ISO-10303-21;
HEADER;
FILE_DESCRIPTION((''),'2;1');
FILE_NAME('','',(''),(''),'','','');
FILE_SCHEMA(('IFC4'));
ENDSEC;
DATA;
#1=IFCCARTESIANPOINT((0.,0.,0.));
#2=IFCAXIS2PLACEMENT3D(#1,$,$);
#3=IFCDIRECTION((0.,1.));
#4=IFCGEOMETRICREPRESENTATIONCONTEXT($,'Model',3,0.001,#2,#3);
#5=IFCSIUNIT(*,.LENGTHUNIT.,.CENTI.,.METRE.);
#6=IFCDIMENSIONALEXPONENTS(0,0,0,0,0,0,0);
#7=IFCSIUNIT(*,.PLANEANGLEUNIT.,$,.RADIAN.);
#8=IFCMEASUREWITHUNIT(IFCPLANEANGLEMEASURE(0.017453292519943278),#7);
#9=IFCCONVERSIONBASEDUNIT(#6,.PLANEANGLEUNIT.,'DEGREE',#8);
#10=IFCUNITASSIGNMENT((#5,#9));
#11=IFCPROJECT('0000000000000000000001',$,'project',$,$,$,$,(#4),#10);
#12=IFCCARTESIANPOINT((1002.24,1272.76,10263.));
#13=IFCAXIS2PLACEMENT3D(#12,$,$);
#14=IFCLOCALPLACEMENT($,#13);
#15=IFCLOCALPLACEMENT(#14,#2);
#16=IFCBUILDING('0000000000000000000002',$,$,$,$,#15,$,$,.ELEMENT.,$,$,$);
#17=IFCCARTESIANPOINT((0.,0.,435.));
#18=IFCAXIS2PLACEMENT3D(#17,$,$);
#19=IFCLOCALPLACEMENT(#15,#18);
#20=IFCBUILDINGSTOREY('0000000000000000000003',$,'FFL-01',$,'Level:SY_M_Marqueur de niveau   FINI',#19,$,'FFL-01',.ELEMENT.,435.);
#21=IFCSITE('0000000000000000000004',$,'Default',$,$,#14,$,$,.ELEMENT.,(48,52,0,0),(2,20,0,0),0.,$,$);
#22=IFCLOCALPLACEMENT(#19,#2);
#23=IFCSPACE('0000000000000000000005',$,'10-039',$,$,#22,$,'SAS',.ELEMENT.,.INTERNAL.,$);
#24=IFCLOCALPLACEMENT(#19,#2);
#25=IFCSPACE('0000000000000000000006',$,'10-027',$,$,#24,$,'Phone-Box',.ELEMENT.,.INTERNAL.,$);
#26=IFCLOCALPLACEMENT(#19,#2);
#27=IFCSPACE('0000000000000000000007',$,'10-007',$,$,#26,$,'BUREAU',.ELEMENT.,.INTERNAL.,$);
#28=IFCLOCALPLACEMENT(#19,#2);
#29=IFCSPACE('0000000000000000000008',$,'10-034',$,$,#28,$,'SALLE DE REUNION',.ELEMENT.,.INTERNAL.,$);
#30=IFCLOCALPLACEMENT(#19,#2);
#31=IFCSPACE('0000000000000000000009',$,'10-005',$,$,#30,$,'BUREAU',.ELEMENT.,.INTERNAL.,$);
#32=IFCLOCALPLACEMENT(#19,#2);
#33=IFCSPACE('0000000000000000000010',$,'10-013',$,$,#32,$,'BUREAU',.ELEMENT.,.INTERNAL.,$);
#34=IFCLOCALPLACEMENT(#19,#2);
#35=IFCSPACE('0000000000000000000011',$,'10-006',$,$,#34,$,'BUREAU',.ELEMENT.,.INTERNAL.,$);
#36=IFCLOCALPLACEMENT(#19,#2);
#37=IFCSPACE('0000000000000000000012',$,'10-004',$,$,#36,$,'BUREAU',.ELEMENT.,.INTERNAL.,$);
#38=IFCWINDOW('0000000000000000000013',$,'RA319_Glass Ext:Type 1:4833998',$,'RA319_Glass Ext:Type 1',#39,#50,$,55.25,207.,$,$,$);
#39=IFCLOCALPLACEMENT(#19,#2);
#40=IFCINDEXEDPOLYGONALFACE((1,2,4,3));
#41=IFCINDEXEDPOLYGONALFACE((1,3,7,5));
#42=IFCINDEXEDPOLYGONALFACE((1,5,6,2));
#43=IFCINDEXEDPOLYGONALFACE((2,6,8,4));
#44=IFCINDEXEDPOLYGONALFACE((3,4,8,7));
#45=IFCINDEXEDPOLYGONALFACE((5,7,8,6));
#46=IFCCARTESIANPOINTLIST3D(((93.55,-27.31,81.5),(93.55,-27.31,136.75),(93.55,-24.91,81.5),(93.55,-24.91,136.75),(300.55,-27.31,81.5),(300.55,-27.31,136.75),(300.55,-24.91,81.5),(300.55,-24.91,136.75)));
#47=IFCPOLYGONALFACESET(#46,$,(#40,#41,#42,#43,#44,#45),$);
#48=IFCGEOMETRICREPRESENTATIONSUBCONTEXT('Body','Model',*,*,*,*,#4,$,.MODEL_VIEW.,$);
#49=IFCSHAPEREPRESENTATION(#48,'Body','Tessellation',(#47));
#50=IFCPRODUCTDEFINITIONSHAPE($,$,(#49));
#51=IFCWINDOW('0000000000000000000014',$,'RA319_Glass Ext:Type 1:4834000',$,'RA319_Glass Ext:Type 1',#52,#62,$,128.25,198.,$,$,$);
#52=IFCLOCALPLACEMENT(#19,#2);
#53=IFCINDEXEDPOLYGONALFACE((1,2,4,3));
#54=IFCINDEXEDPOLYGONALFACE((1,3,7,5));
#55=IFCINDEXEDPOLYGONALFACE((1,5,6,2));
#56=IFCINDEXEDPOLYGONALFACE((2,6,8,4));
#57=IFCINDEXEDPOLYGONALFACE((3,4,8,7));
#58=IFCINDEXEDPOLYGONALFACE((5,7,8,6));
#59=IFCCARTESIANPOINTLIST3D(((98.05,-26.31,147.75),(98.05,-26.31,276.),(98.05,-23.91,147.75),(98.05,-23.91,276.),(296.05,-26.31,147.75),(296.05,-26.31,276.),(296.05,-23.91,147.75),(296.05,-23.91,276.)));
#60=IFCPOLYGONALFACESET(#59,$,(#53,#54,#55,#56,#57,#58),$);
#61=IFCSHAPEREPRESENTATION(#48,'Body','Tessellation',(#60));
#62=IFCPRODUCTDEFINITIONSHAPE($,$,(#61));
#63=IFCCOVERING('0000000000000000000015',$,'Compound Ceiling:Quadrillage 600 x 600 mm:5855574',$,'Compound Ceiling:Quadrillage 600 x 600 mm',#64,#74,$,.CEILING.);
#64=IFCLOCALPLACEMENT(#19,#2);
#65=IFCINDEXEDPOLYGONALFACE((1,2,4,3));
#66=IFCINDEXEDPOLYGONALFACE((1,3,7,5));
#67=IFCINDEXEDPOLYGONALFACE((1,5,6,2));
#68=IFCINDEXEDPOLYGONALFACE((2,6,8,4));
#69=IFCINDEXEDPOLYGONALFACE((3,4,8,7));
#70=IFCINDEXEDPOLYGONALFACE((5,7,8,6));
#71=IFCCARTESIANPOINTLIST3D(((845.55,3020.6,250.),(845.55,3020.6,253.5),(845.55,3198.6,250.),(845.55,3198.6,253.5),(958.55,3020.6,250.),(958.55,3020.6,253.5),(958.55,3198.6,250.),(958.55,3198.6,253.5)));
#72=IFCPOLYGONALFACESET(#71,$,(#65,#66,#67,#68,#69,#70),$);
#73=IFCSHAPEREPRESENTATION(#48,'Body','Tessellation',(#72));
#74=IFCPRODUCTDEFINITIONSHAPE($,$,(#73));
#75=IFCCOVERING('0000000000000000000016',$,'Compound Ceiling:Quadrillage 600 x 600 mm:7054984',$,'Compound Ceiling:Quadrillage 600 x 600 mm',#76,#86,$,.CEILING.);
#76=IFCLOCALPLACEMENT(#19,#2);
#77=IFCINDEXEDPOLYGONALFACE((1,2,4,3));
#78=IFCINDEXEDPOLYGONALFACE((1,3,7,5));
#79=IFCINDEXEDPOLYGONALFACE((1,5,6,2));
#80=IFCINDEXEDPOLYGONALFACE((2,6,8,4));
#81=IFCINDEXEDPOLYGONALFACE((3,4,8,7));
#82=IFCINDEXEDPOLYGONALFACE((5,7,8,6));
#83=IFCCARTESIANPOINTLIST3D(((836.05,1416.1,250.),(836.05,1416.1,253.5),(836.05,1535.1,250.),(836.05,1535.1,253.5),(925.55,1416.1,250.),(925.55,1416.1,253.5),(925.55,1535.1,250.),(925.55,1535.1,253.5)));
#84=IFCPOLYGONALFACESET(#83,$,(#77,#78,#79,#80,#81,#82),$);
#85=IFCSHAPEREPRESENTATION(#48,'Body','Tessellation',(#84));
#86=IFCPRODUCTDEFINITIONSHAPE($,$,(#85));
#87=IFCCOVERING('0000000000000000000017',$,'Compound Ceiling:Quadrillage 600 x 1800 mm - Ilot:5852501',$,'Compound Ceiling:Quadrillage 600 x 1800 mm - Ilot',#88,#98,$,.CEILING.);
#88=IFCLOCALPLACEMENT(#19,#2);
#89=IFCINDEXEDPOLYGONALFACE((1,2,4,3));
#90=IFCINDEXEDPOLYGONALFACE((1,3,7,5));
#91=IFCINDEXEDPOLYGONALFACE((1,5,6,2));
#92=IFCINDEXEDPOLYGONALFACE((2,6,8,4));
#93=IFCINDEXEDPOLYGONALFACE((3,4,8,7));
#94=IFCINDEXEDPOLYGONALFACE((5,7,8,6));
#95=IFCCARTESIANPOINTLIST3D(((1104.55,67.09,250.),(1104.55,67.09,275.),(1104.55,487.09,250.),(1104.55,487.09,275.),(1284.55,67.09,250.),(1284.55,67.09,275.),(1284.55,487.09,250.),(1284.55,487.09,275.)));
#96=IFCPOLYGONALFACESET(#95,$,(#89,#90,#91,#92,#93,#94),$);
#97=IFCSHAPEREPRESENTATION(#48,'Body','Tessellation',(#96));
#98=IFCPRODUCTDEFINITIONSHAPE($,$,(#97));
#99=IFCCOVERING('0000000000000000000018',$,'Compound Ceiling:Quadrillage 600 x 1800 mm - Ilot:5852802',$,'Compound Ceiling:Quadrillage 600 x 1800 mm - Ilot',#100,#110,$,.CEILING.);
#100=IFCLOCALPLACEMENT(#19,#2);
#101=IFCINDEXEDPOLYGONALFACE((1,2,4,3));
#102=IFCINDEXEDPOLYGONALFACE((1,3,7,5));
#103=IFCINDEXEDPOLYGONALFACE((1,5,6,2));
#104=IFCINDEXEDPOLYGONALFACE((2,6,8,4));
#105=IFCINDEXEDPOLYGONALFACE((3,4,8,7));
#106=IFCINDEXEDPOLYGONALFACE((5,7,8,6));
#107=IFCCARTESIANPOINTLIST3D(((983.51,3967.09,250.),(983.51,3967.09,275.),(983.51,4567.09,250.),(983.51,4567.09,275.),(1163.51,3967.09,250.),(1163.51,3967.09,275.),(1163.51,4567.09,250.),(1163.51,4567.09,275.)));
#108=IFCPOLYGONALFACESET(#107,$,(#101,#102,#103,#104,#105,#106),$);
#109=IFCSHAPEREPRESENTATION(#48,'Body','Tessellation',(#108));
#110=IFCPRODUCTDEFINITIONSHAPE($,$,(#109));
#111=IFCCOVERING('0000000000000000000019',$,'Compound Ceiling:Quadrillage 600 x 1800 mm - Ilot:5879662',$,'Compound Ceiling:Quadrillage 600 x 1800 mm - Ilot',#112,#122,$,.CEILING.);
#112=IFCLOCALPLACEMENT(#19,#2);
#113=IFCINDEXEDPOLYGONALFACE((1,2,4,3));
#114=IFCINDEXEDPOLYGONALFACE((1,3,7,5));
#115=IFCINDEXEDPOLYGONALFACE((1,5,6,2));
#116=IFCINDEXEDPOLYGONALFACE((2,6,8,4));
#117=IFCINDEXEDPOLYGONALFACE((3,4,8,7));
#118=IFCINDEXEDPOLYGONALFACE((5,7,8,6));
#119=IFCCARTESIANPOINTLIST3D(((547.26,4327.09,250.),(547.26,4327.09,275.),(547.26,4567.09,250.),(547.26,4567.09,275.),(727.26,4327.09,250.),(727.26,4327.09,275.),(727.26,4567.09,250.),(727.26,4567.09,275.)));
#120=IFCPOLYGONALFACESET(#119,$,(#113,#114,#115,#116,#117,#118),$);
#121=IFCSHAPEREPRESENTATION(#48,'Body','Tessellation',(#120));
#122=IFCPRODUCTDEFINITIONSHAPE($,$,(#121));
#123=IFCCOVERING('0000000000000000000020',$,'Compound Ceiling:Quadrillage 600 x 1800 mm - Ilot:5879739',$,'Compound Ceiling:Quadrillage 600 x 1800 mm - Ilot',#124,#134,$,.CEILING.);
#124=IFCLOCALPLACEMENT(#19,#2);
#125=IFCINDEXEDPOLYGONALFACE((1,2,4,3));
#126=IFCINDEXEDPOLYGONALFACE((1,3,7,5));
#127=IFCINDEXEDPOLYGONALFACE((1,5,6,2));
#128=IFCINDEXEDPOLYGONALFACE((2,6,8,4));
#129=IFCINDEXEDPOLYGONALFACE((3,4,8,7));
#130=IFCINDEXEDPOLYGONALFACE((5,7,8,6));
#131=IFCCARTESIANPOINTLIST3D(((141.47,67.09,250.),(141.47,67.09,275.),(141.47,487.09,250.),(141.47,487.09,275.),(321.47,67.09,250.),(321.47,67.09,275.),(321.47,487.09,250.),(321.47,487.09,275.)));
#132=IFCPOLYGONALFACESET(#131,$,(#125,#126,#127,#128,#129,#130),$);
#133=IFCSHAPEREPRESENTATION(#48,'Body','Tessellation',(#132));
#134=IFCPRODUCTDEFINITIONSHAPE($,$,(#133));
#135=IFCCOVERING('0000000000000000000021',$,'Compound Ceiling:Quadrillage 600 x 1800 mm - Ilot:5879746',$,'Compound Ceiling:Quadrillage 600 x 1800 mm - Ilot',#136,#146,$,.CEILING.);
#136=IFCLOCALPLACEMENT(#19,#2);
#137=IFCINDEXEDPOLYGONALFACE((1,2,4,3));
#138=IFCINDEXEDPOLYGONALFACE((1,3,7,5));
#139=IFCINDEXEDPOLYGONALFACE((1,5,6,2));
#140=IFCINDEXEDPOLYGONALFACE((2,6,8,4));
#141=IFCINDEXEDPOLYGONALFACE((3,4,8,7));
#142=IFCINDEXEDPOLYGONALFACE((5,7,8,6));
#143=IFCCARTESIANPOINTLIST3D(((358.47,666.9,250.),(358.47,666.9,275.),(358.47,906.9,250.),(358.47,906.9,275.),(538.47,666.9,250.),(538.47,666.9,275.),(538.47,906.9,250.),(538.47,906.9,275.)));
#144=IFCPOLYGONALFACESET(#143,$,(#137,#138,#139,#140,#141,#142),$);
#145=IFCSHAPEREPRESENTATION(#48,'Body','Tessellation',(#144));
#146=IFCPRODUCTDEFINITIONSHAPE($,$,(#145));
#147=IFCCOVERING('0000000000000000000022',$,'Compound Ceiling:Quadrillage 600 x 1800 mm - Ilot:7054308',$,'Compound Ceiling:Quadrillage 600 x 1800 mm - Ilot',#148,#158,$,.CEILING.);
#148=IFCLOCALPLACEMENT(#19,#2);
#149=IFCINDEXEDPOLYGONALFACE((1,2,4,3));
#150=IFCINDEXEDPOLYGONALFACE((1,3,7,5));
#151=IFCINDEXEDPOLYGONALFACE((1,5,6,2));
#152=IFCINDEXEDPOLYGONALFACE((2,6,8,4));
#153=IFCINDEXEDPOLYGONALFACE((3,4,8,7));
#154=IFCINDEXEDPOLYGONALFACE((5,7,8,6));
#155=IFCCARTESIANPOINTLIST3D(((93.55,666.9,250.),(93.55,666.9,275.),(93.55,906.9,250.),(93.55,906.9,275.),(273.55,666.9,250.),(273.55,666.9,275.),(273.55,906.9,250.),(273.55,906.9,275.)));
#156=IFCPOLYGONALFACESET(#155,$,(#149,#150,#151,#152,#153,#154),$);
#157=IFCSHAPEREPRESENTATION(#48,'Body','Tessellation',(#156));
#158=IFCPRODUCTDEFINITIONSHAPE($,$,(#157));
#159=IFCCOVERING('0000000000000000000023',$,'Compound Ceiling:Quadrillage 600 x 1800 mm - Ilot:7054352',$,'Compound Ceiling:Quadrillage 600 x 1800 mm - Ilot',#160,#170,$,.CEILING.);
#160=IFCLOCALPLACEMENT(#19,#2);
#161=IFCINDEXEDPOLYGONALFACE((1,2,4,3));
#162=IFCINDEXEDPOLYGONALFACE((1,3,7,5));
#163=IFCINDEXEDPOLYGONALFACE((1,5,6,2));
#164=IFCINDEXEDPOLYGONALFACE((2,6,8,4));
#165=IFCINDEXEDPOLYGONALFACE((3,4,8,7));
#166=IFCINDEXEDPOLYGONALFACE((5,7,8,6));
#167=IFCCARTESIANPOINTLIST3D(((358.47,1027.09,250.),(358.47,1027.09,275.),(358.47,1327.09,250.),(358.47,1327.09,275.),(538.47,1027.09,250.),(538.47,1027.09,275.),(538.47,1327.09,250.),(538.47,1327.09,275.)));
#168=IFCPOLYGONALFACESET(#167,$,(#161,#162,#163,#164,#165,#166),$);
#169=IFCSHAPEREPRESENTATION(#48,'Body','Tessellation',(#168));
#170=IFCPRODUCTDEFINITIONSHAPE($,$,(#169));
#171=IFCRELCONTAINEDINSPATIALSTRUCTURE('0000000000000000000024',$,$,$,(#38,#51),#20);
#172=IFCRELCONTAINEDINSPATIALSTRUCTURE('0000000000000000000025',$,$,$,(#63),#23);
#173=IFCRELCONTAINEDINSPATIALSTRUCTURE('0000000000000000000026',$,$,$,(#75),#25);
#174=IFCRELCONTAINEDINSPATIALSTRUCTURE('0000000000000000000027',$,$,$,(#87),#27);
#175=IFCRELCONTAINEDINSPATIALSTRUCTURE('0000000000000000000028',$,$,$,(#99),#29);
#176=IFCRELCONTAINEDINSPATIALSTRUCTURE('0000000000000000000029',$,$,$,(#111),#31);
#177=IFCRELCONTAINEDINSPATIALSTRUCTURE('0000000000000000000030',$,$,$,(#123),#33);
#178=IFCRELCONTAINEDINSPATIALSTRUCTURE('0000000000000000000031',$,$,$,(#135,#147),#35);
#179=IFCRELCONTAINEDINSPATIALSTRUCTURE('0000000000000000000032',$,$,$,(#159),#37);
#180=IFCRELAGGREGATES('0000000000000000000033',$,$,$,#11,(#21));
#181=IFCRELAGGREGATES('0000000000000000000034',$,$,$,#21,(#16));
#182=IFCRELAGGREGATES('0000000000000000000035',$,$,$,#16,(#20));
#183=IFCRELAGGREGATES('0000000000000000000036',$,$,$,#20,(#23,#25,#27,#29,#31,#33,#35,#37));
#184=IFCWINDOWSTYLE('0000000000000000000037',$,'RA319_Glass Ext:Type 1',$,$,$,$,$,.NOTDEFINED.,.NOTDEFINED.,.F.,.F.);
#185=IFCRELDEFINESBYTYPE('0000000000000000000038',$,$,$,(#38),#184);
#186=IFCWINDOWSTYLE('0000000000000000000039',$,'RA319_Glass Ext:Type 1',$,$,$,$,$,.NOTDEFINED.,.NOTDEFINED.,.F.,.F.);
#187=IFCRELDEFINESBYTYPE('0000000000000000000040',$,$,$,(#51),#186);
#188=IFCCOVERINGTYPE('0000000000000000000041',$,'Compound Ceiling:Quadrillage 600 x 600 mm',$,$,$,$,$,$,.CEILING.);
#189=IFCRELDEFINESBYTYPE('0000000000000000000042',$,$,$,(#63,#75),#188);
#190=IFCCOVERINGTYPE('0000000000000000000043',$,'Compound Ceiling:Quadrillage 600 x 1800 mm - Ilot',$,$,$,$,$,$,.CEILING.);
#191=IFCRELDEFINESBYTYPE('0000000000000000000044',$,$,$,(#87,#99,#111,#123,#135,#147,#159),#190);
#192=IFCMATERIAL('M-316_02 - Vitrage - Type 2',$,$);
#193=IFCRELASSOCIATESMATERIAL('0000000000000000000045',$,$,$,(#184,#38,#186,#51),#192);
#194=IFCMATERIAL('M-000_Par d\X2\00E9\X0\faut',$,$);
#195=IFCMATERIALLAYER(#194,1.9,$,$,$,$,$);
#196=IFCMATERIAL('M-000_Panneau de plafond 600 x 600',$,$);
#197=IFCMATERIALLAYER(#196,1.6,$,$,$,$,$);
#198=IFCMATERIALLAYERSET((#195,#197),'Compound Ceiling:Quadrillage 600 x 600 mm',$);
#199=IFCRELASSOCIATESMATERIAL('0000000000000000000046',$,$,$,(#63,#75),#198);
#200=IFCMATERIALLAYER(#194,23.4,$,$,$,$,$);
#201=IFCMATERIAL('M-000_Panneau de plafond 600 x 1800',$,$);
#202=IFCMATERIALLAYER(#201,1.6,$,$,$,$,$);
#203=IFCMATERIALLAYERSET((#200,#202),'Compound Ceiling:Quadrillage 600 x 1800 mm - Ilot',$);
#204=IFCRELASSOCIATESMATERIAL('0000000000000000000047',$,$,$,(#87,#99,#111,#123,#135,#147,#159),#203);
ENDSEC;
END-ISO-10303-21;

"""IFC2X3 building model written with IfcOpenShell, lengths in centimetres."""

from ifc_helpers import new_model, entity, si_unit, converted_unit, direction, frame, frame_2d, origin, origin_2d_with_axis, place, context, subcontext, project, spatial, rectangle, extrude, source, transform, mapped, material, layer, layer_set, layer_usage, type_object, type_shapes, element, save


model = new_model("IFC2X3")

# Units and contexts
model_context = context("Model", 3, precision=0.001, world=origin(), true_north=direction((0.0, 1.0)))
body_context = subcontext(model_context, "Body", "Model", "MODEL_VIEW")
ifc_project = project(units=[si_unit("LENGTHUNIT", "METRE", prefix="CENTI"), converted_unit("PLANEANGLEUNIT", "DEGREE", entity("IfcPlaneAngleMeasure", 0.017453292519943278), si_unit("PLANEANGLEUNIT", "RADIAN"), dimensions=[0, 0, 0, 0, 0, 0, 0])], contexts=[model_context])

# Site, building, storey
site_placement = place(None, frame((1002.24, 1272.76, 10263.0)))
site = spatial("IfcSite", under=ifc_project, at=site_placement, Name="Default", CompositionType="ELEMENT", RefLatitude=(48, 52, 0, 0), RefLongitude=(2, 20, 0, 0), RefElevation=0.0)
building_placement = place(site_placement, origin())
building = spatial("IfcBuilding", under=site, at=building_placement, CompositionType="ELEMENT")
storey_placement = place(building_placement, frame((0.0, 0.0, 435.0)))
storey = spatial("IfcBuildingStorey", under=building, at=storey_placement, Name="FFL-01", ObjectType="Level:SY_M_Marqueur de niveau   FINI", LongName="FFL-01", CompositionType="ELEMENT", Elevation=435.0)

# Windows
ifc_material_1 = material(Name="M-316_02 - Vitrage - Type 2")
window_style_1 = type_object("IfcWindowStyle", Name="RA319_Glass Ext:Type 1", ConstructionType="NOTDEFINED", OperationType="NOTDEFINED", ParameterTakesPrecedence=False, Sizeable=False, material=ifc_material_1)
shared_shape_1 = source(origin(), body_context, "Body", "SweptSolid", [
    extrude(rectangle(XDim=207.0, YDim=55.25, at=frame_2d((0.0, 0.0), x_axis=(1.0, 0.0))), frame((0.0, 0.0, 0.0), z_axis=(0.0, 0.0, 1.0), x_axis=(-1.0, 0.0, 0.0)), (0.0, 0.0, 1.0), 2.4),
])
type_shapes(window_style_1, [shared_shape_1])
window_1_placement = place(storey_placement, frame((197.05, -27.31, 109.13), z_axis=(0.0, 1.0, 0.0), x_axis=(-1.0, 0.0, 0.0)))
element("IfcWindow", 1, at=window_1_placement, inside=storey, type_object=window_style_1, material=ifc_material_1, Name="RA319_Glass Ext:Type 1:4833998", ObjectType="RA319_Glass Ext:Type 1", OverallHeight=55.25, OverallWidth=207.0, context=body_context, shape_type="MappedRepresentation", body=[
    mapped(shared_shape_1, transform((0.0, 0.0, 0.0), scale=1.0)),
])
window_style_2 = type_object("IfcWindowStyle", Name="RA319_Glass Ext:Type 1", ConstructionType="NOTDEFINED", OperationType="NOTDEFINED", ParameterTakesPrecedence=False, Sizeable=False, material=ifc_material_1)
shared_shape_2 = source(origin(), body_context, "Body", "SweptSolid", [
    extrude(rectangle(XDim=198.0, YDim=128.25, at=frame_2d((0.0, 0.0), x_axis=(1.0, 0.0))), frame((0.0, 0.0, 0.0), z_axis=(0.0, 0.0, 1.0), x_axis=(-1.0, 0.0, 0.0)), (0.0, 0.0, 1.0), 2.4),
])
type_shapes(window_style_2, [shared_shape_2])
window_2_placement = place(storey_placement, frame((197.05, -26.31, 211.88), z_axis=(0.0, 1.0, 0.0), x_axis=(-1.0, 0.0, 0.0)))
element("IfcWindow", 2, at=window_2_placement, inside=storey, type_object=window_style_2, material=ifc_material_1, Name="RA319_Glass Ext:Type 1:4834000", ObjectType="RA319_Glass Ext:Type 1", OverallHeight=128.25, OverallWidth=198.0, context=body_context, shape_type="MappedRepresentation", body=[
    mapped(shared_shape_2, transform((0.0, 0.0, 0.0), scale=1.0)),
])

# Shared definitions
space_1_placement = place(storey_placement, origin())
space_1 = spatial("IfcSpace", under=storey, at=space_1_placement, Name="10-039", LongName="SAS", CompositionType="ELEMENT", InteriorOrExteriorSpace="INTERNAL")

# Covering
ifc_material_2 = material(Name="M-000_Par défaut")
ifc_layer_1 = layer(ifc_material_2, 1.9)
ifc_material_3 = material(Name="M-000_Panneau de plafond 600 x 600")
ifc_layer_2 = layer(ifc_material_3, 1.6)
ifc_layer_set_1 = layer_set([ifc_layer_1, ifc_layer_2], Name="Compound Ceiling:Quadrillage 600 x 600 mm")
ifc_layer_usage_1 = layer_usage(ifc_layer_set_1, "AXIS3", "NEGATIVE", 3.5)
covering_type_1 = type_object("IfcCoveringType", Name="Compound Ceiling:Quadrillage 600 x 600 mm", PredefinedType="CEILING")
covering_1_placement = place(space_1_placement, origin())
element("IfcCovering", 3, at=covering_1_placement, inside=space_1, type_object=covering_type_1, material=ifc_layer_usage_1, Name="Compound Ceiling:Quadrillage 600 x 600 mm:5855574", ObjectType="Compound Ceiling:Quadrillage 600 x 600 mm", PredefinedType="CEILING", context=body_context, shape_type="SweptSolid", body=[
    extrude(rectangle(XDim=178.0, YDim=112.99, at=frame_2d((0.0, 0.0), x_axis=(1.0, 0.0))), frame((902.05, 3109.6, 250.0), z_axis=(0.0, 0.0, 1.0), x_axis=(0.0, 1.0, 0.0)), (0.0, 0.0, 1.0), 3.5),
])

# Shared definitions
space_2_placement = place(storey_placement, origin())
space_2 = spatial("IfcSpace", under=storey, at=space_2_placement, Name="10-027", LongName="Phone-Box", CompositionType="ELEMENT", InteriorOrExteriorSpace="INTERNAL")

# Covering
ifc_layer_usage_2 = layer_usage(ifc_layer_set_1, "AXIS3", "NEGATIVE", 3.5)
covering_2_placement = place(space_2_placement, origin())
element("IfcCovering", 4, at=covering_2_placement, inside=space_2, type_object=covering_type_1, material=ifc_layer_usage_2, Name="Compound Ceiling:Quadrillage 600 x 600 mm:7054984", ObjectType="Compound Ceiling:Quadrillage 600 x 600 mm", PredefinedType="CEILING", context=body_context, shape_type="SweptSolid", body=[
    extrude(rectangle(XDim=89.49, YDim=119.0, at=frame_2d((0.0, 0.0), x_axis=(1.0, 0.0))), frame((880.8, 1475.6, 250.0)), (0.0, 0.0, 1.0), 3.5),
])

# Shared definitions
space_3_placement = place(storey_placement, origin())
space_3 = spatial("IfcSpace", under=storey, at=space_3_placement, Name="10-007", LongName="BUREAU", CompositionType="ELEMENT", InteriorOrExteriorSpace="INTERNAL")

# Covering
ifc_layer_3 = layer(ifc_material_2, 23.4)
ifc_material_4 = material(Name="M-000_Panneau de plafond 600 x 1800")
ifc_layer_4 = layer(ifc_material_4, 1.6)
ifc_layer_set_2 = layer_set([ifc_layer_3, ifc_layer_4], Name="Compound Ceiling:Quadrillage 600 x 1800 mm - Ilot")
ifc_layer_usage_3 = layer_usage(ifc_layer_set_2, "AXIS3", "NEGATIVE", 25.0)
covering_type_2 = type_object("IfcCoveringType", Name="Compound Ceiling:Quadrillage 600 x 1800 mm - Ilot", PredefinedType="CEILING")
covering_3_placement = place(space_3_placement, origin())
element("IfcCovering", 5, at=covering_3_placement, inside=space_3, type_object=covering_type_2, material=ifc_layer_usage_3, Name="Compound Ceiling:Quadrillage 600 x 1800 mm - Ilot:5852501", ObjectType="Compound Ceiling:Quadrillage 600 x 1800 mm - Ilot", PredefinedType="CEILING", context=body_context, shape_type="SweptSolid", body=[
    extrude(rectangle(XDim=180.0, YDim=420.0, at=origin_2d_with_axis()), frame((1194.55, 277.09, 250.0), z_axis=(0.0, 0.0, 1.0), x_axis=(-1.0, 0.0, 0.0)), (0.0, 0.0, 1.0), 25.0),
])

# Shared definitions
space_4_placement = place(storey_placement, origin())
space_4 = spatial("IfcSpace", under=storey, at=space_4_placement, Name="10-034", LongName="SALLE DE REUNION", CompositionType="ELEMENT", InteriorOrExteriorSpace="INTERNAL")

# Covering
ifc_layer_usage_4 = layer_usage(ifc_layer_set_2, "AXIS3", "NEGATIVE", 25.0)
covering_4_placement = place(space_4_placement, origin())
element("IfcCovering", 6, at=covering_4_placement, inside=space_4, type_object=covering_type_2, material=ifc_layer_usage_4, Name="Compound Ceiling:Quadrillage 600 x 1800 mm - Ilot:5852802", ObjectType="Compound Ceiling:Quadrillage 600 x 1800 mm - Ilot", PredefinedType="CEILING", context=body_context, shape_type="SweptSolid", body=[
    extrude(rectangle(XDim=180.0, YDim=600.0, at=frame_2d((0.0, 0.0), x_axis=(1.0, 0.0))), frame((1073.51, 4267.09, 250.0), z_axis=(0.0, 0.0, 1.0), x_axis=(-1.0, 0.0, 0.0)), (0.0, 0.0, 1.0), 25.0),
])

# Shared definitions
space_5_placement = place(storey_placement, origin())
space_5 = spatial("IfcSpace", under=storey, at=space_5_placement, Name="10-005", LongName="BUREAU", CompositionType="ELEMENT", InteriorOrExteriorSpace="INTERNAL")

# Covering
ifc_layer_usage_5 = layer_usage(ifc_layer_set_2, "AXIS3", "NEGATIVE", 25.0)
covering_5_placement = place(space_5_placement, origin())
element("IfcCovering", 7, at=covering_5_placement, inside=space_5, type_object=covering_type_2, material=ifc_layer_usage_5, Name="Compound Ceiling:Quadrillage 600 x 1800 mm - Ilot:5879662", ObjectType="Compound Ceiling:Quadrillage 600 x 1800 mm - Ilot", PredefinedType="CEILING", context=body_context, shape_type="SweptSolid", body=[
    extrude(rectangle(XDim=180.0, YDim=240.0, at=frame_2d((0.0, 0.0), x_axis=(1.0, 0.0))), frame((637.26, 4447.09, 250.0), z_axis=(0.0, 0.0, 1.0), x_axis=(-1.0, 0.0, 0.0)), (0.0, 0.0, 1.0), 25.0),
])

# Shared definitions
space_6_placement = place(storey_placement, origin())
space_6 = spatial("IfcSpace", under=storey, at=space_6_placement, Name="10-013", LongName="BUREAU", CompositionType="ELEMENT", InteriorOrExteriorSpace="INTERNAL")

# Covering
ifc_layer_usage_6 = layer_usage(ifc_layer_set_2, "AXIS3", "NEGATIVE", 25.0)
covering_6_placement = place(space_6_placement, origin())
element("IfcCovering", 8, at=covering_6_placement, inside=space_6, type_object=covering_type_2, material=ifc_layer_usage_6, Name="Compound Ceiling:Quadrillage 600 x 1800 mm - Ilot:5879739", ObjectType="Compound Ceiling:Quadrillage 600 x 1800 mm - Ilot", PredefinedType="CEILING", context=body_context, shape_type="SweptSolid", body=[
    extrude(rectangle(XDim=180.0, YDim=420.0, at=origin_2d_with_axis()), frame((231.47, 277.09, 250.0), z_axis=(0.0, 0.0, 1.0), x_axis=(-1.0, 0.0, 0.0)), (0.0, 0.0, 1.0), 25.0),
])

# Shared definitions
space_7_placement = place(storey_placement, origin())
space_7 = spatial("IfcSpace", under=storey, at=space_7_placement, Name="10-006", LongName="BUREAU", CompositionType="ELEMENT", InteriorOrExteriorSpace="INTERNAL")

# Coverings
ifc_layer_usage_7 = layer_usage(ifc_layer_set_2, "AXIS3", "NEGATIVE", 25.0)
covering_7_placement = place(space_7_placement, origin())
element("IfcCovering", 9, at=covering_7_placement, inside=space_7, type_object=covering_type_2, material=ifc_layer_usage_7, Name="Compound Ceiling:Quadrillage 600 x 1800 mm - Ilot:5879746", ObjectType="Compound Ceiling:Quadrillage 600 x 1800 mm - Ilot", PredefinedType="CEILING", context=body_context, shape_type="SweptSolid", body=[
    extrude(rectangle(XDim=240.0, YDim=180.0, at=origin_2d_with_axis()), frame((448.47, 786.9, 250.0), z_axis=(0.0, 0.0, 1.0), x_axis=(0.0, -1.0, 0.0)), (0.0, 0.0, 1.0), 25.0),
])
ifc_layer_usage_8 = layer_usage(ifc_layer_set_2, "AXIS3", "NEGATIVE", 25.0)
covering_8_placement = place(space_7_placement, origin())
element("IfcCovering", 10, at=covering_8_placement, inside=space_7, type_object=covering_type_2, material=ifc_layer_usage_8, Name="Compound Ceiling:Quadrillage 600 x 1800 mm - Ilot:7054308", ObjectType="Compound Ceiling:Quadrillage 600 x 1800 mm - Ilot", PredefinedType="CEILING", context=body_context, shape_type="SweptSolid", body=[
    extrude(rectangle(XDim=240.0, YDim=180.0, at=origin_2d_with_axis()), frame((183.55, 786.9, 250.0), z_axis=(0.0, 0.0, 1.0), x_axis=(0.0, -1.0, 0.0)), (0.0, 0.0, 1.0), 25.0),
])

# Shared definitions
space_8_placement = place(storey_placement, origin())
space_8 = spatial("IfcSpace", under=storey, at=space_8_placement, Name="10-004", LongName="BUREAU", CompositionType="ELEMENT", InteriorOrExteriorSpace="INTERNAL")

# Covering
ifc_layer_usage_9 = layer_usage(ifc_layer_set_2, "AXIS3", "NEGATIVE", 25.0)
covering_9_placement = place(space_8_placement, origin())
element("IfcCovering", 11, at=covering_9_placement, inside=space_8, type_object=covering_type_2, material=ifc_layer_usage_9, Name="Compound Ceiling:Quadrillage 600 x 1800 mm - Ilot:7054352", ObjectType="Compound Ceiling:Quadrillage 600 x 1800 mm - Ilot", PredefinedType="CEILING", context=body_context, shape_type="SweptSolid", body=[
    extrude(rectangle(XDim=300.0, YDim=180.0, at=frame_2d((0.0, 0.0), x_axis=(1.0, 0.0))), frame((448.47, 1177.09, 250.0), z_axis=(0.0, 0.0, 1.0), x_axis=(0.0, -1.0, 0.0)), (0.0, 0.0, 1.0), 25.0),
])

save(model, "model.ifc")
